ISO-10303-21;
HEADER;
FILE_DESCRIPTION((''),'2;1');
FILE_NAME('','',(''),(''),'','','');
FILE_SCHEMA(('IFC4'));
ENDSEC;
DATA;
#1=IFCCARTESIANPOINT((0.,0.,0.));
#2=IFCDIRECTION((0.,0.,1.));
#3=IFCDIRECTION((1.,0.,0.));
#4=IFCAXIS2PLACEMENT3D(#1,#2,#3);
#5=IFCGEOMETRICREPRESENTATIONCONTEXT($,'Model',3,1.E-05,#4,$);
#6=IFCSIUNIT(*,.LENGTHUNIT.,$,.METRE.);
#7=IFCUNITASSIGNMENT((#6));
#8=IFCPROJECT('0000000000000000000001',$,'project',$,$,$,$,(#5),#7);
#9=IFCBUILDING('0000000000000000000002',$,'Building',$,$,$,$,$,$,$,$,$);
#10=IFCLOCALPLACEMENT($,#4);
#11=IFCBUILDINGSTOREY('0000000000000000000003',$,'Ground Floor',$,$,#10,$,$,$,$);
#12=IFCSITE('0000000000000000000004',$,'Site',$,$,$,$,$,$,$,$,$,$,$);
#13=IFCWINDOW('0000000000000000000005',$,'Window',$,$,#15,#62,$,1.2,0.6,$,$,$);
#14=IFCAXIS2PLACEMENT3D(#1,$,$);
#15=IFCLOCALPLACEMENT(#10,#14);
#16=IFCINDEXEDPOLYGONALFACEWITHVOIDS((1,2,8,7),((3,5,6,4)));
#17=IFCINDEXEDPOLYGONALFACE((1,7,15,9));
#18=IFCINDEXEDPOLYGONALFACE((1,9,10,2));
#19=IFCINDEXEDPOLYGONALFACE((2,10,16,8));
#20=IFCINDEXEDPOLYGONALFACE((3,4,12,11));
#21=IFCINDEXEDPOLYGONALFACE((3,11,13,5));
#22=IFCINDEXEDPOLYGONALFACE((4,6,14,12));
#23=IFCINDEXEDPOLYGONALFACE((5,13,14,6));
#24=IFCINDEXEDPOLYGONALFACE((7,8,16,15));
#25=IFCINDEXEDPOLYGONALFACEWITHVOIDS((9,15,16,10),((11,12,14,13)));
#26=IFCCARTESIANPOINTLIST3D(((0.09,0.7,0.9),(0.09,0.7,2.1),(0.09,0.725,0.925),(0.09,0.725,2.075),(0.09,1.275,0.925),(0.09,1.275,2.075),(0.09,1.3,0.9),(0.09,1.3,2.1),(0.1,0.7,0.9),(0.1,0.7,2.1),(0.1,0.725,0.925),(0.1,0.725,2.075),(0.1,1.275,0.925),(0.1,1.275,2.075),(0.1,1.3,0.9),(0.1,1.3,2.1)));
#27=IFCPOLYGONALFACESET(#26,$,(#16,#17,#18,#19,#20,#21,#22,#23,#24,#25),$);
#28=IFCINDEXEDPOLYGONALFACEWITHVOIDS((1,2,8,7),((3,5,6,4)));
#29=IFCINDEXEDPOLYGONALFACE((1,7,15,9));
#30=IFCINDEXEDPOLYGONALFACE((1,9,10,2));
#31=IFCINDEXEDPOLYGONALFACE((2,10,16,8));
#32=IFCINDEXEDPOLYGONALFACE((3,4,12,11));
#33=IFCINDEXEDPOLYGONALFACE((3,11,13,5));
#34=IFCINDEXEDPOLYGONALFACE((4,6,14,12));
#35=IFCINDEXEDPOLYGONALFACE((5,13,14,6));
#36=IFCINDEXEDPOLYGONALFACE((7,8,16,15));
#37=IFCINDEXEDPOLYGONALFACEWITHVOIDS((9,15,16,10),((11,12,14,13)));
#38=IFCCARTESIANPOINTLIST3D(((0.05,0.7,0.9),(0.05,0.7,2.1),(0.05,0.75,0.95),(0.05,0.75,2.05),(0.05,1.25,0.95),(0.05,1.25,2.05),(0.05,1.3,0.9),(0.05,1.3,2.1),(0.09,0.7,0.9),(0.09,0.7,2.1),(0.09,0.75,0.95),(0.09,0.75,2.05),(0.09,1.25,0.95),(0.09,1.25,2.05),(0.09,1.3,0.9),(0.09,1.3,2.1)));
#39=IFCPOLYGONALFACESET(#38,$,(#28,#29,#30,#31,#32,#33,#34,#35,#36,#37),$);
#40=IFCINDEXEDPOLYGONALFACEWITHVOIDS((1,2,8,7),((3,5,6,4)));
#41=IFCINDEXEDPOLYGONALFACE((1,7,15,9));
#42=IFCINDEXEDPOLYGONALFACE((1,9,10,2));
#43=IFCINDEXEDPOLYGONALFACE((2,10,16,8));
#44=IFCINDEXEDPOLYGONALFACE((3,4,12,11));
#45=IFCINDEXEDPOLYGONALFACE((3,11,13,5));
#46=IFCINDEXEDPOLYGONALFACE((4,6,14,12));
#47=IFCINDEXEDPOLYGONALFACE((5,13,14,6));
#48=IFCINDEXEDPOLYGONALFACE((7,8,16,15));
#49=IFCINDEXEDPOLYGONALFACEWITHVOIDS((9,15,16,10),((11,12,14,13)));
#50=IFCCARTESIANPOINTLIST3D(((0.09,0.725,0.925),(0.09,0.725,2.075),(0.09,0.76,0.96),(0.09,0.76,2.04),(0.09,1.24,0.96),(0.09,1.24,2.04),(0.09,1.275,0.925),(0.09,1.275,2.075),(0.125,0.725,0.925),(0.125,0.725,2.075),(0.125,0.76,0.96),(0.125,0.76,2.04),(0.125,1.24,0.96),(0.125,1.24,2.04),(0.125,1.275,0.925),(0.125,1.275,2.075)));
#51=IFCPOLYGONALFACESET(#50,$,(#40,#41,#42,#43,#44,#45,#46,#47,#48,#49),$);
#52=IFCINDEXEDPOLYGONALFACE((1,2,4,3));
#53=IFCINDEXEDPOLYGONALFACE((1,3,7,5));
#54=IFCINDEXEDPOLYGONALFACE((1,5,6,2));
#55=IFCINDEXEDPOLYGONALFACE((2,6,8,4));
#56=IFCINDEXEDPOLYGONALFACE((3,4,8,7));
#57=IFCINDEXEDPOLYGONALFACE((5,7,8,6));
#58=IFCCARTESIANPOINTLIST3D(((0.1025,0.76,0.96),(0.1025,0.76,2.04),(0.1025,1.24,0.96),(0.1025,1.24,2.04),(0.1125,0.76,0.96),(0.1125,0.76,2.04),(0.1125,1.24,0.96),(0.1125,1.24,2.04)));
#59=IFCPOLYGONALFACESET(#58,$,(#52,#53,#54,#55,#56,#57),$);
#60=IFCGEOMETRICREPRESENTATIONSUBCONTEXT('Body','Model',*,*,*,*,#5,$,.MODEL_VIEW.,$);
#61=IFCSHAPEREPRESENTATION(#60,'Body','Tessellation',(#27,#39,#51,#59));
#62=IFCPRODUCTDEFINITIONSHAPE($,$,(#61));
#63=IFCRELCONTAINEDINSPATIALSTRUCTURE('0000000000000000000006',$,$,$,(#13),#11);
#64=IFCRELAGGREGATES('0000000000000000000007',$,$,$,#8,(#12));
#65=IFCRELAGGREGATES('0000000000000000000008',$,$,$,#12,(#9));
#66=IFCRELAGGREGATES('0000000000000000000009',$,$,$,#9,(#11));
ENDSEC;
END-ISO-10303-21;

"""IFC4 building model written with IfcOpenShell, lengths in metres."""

from ifc_helpers import new_model, si_unit, frame, origin_with_axes, place, context, subcontext, project, spatial, line, indexed_curve, outline, extrude, element, save


model = new_model("IFC4")

# Units and contexts
model_context = context("Model", 3, precision=1e-05, world=origin_with_axes())
body_context = subcontext(model_context, "Body", "Model", "MODEL_VIEW")
ifc_project = project(units=[si_unit("LENGTHUNIT", "METRE")], contexts=[model_context])

# Site, building, storey
site = spatial("IfcSite", under=ifc_project, Name="Site")
building = spatial("IfcBuilding", under=site, Name="Building")
storey_placement = place(None, origin_with_axes())
storey = spatial("IfcBuildingStorey", under=building, at=storey_placement, Name="Ground Floor")

# Window
window_1_placement = place(storey_placement, frame((0.0, 1.3, 0.9), z_axis=(0.0, 0.0, 1.0), x_axis=(0.0, -1.0, 0.0)))
element("IfcWindow", 1, at=window_1_placement, inside=storey, Name="Window", OverallHeight=1.2, OverallWidth=0.6, context=body_context, shape_type="SweptSolid", body=[
    extrude(outline(indexed_curve([(0.0, 0.0), (0.6, 0.0), (0.6, 1.2), (0.0, 1.2)], segments=[line(1, 2, 3, 4, 1)]), holes=[indexed_curve([(0.025, 0.025), (0.575, 0.025), (0.575, 1.175), (0.025, 1.175)], segments=[line(1, 2, 3, 4, 1)])]), frame((0.0, 0.09, 0.0), z_axis=(0.0, -1.0, 0.0), x_axis=(1.0, 0.0, 0.0)), (0.0, 0.0, -1.0), 0.01),
    extrude(outline(indexed_curve([(0.0, 0.0), (0.6, 0.0), (0.6, 1.2), (0.0, 1.2)], segments=[line(1, 2, 3, 4, 1)]), holes=[indexed_curve([(0.05, 0.05), (0.55, 0.05), (0.55, 1.15), (0.05, 1.15)], segments=[line(1, 2, 3, 4, 1)])]), frame((0.0, 0.05, 0.0), z_axis=(0.0, -1.0, 0.0), x_axis=(1.0, 0.0, 0.0)), (0.0, 0.0, -1.0), 0.04),
    extrude(outline(indexed_curve([(0.0, 0.0), (0.55, 0.0), (0.55, 1.15), (0.0, 1.15)], segments=[line(1, 2, 3, 4, 1)]), holes=[indexed_curve([(0.035, 0.035), (0.515, 0.035), (0.515, 1.115), (0.035, 1.115)], segments=[line(1, 2, 3, 4, 1)])]), frame((0.025, 0.09, 0.025), z_axis=(0.0, -1.0, 0.0), x_axis=(1.0, 0.0, 0.0)), (0.0, 0.0, -1.0), 0.035),
    extrude(outline(indexed_curve([(0.035, 0.035), (0.515, 0.035), (0.515, 1.115), (0.035, 1.115)], segments=[line(1, 2, 3, 4, 1)])), frame((0.025, 0.1025, 0.025), z_axis=(0.0, -1.0, 0.0), x_axis=(1.0, 0.0, 0.0)), (0.0, 0.0, -1.0), 0.01),
])

save(model, "model.ifc")
